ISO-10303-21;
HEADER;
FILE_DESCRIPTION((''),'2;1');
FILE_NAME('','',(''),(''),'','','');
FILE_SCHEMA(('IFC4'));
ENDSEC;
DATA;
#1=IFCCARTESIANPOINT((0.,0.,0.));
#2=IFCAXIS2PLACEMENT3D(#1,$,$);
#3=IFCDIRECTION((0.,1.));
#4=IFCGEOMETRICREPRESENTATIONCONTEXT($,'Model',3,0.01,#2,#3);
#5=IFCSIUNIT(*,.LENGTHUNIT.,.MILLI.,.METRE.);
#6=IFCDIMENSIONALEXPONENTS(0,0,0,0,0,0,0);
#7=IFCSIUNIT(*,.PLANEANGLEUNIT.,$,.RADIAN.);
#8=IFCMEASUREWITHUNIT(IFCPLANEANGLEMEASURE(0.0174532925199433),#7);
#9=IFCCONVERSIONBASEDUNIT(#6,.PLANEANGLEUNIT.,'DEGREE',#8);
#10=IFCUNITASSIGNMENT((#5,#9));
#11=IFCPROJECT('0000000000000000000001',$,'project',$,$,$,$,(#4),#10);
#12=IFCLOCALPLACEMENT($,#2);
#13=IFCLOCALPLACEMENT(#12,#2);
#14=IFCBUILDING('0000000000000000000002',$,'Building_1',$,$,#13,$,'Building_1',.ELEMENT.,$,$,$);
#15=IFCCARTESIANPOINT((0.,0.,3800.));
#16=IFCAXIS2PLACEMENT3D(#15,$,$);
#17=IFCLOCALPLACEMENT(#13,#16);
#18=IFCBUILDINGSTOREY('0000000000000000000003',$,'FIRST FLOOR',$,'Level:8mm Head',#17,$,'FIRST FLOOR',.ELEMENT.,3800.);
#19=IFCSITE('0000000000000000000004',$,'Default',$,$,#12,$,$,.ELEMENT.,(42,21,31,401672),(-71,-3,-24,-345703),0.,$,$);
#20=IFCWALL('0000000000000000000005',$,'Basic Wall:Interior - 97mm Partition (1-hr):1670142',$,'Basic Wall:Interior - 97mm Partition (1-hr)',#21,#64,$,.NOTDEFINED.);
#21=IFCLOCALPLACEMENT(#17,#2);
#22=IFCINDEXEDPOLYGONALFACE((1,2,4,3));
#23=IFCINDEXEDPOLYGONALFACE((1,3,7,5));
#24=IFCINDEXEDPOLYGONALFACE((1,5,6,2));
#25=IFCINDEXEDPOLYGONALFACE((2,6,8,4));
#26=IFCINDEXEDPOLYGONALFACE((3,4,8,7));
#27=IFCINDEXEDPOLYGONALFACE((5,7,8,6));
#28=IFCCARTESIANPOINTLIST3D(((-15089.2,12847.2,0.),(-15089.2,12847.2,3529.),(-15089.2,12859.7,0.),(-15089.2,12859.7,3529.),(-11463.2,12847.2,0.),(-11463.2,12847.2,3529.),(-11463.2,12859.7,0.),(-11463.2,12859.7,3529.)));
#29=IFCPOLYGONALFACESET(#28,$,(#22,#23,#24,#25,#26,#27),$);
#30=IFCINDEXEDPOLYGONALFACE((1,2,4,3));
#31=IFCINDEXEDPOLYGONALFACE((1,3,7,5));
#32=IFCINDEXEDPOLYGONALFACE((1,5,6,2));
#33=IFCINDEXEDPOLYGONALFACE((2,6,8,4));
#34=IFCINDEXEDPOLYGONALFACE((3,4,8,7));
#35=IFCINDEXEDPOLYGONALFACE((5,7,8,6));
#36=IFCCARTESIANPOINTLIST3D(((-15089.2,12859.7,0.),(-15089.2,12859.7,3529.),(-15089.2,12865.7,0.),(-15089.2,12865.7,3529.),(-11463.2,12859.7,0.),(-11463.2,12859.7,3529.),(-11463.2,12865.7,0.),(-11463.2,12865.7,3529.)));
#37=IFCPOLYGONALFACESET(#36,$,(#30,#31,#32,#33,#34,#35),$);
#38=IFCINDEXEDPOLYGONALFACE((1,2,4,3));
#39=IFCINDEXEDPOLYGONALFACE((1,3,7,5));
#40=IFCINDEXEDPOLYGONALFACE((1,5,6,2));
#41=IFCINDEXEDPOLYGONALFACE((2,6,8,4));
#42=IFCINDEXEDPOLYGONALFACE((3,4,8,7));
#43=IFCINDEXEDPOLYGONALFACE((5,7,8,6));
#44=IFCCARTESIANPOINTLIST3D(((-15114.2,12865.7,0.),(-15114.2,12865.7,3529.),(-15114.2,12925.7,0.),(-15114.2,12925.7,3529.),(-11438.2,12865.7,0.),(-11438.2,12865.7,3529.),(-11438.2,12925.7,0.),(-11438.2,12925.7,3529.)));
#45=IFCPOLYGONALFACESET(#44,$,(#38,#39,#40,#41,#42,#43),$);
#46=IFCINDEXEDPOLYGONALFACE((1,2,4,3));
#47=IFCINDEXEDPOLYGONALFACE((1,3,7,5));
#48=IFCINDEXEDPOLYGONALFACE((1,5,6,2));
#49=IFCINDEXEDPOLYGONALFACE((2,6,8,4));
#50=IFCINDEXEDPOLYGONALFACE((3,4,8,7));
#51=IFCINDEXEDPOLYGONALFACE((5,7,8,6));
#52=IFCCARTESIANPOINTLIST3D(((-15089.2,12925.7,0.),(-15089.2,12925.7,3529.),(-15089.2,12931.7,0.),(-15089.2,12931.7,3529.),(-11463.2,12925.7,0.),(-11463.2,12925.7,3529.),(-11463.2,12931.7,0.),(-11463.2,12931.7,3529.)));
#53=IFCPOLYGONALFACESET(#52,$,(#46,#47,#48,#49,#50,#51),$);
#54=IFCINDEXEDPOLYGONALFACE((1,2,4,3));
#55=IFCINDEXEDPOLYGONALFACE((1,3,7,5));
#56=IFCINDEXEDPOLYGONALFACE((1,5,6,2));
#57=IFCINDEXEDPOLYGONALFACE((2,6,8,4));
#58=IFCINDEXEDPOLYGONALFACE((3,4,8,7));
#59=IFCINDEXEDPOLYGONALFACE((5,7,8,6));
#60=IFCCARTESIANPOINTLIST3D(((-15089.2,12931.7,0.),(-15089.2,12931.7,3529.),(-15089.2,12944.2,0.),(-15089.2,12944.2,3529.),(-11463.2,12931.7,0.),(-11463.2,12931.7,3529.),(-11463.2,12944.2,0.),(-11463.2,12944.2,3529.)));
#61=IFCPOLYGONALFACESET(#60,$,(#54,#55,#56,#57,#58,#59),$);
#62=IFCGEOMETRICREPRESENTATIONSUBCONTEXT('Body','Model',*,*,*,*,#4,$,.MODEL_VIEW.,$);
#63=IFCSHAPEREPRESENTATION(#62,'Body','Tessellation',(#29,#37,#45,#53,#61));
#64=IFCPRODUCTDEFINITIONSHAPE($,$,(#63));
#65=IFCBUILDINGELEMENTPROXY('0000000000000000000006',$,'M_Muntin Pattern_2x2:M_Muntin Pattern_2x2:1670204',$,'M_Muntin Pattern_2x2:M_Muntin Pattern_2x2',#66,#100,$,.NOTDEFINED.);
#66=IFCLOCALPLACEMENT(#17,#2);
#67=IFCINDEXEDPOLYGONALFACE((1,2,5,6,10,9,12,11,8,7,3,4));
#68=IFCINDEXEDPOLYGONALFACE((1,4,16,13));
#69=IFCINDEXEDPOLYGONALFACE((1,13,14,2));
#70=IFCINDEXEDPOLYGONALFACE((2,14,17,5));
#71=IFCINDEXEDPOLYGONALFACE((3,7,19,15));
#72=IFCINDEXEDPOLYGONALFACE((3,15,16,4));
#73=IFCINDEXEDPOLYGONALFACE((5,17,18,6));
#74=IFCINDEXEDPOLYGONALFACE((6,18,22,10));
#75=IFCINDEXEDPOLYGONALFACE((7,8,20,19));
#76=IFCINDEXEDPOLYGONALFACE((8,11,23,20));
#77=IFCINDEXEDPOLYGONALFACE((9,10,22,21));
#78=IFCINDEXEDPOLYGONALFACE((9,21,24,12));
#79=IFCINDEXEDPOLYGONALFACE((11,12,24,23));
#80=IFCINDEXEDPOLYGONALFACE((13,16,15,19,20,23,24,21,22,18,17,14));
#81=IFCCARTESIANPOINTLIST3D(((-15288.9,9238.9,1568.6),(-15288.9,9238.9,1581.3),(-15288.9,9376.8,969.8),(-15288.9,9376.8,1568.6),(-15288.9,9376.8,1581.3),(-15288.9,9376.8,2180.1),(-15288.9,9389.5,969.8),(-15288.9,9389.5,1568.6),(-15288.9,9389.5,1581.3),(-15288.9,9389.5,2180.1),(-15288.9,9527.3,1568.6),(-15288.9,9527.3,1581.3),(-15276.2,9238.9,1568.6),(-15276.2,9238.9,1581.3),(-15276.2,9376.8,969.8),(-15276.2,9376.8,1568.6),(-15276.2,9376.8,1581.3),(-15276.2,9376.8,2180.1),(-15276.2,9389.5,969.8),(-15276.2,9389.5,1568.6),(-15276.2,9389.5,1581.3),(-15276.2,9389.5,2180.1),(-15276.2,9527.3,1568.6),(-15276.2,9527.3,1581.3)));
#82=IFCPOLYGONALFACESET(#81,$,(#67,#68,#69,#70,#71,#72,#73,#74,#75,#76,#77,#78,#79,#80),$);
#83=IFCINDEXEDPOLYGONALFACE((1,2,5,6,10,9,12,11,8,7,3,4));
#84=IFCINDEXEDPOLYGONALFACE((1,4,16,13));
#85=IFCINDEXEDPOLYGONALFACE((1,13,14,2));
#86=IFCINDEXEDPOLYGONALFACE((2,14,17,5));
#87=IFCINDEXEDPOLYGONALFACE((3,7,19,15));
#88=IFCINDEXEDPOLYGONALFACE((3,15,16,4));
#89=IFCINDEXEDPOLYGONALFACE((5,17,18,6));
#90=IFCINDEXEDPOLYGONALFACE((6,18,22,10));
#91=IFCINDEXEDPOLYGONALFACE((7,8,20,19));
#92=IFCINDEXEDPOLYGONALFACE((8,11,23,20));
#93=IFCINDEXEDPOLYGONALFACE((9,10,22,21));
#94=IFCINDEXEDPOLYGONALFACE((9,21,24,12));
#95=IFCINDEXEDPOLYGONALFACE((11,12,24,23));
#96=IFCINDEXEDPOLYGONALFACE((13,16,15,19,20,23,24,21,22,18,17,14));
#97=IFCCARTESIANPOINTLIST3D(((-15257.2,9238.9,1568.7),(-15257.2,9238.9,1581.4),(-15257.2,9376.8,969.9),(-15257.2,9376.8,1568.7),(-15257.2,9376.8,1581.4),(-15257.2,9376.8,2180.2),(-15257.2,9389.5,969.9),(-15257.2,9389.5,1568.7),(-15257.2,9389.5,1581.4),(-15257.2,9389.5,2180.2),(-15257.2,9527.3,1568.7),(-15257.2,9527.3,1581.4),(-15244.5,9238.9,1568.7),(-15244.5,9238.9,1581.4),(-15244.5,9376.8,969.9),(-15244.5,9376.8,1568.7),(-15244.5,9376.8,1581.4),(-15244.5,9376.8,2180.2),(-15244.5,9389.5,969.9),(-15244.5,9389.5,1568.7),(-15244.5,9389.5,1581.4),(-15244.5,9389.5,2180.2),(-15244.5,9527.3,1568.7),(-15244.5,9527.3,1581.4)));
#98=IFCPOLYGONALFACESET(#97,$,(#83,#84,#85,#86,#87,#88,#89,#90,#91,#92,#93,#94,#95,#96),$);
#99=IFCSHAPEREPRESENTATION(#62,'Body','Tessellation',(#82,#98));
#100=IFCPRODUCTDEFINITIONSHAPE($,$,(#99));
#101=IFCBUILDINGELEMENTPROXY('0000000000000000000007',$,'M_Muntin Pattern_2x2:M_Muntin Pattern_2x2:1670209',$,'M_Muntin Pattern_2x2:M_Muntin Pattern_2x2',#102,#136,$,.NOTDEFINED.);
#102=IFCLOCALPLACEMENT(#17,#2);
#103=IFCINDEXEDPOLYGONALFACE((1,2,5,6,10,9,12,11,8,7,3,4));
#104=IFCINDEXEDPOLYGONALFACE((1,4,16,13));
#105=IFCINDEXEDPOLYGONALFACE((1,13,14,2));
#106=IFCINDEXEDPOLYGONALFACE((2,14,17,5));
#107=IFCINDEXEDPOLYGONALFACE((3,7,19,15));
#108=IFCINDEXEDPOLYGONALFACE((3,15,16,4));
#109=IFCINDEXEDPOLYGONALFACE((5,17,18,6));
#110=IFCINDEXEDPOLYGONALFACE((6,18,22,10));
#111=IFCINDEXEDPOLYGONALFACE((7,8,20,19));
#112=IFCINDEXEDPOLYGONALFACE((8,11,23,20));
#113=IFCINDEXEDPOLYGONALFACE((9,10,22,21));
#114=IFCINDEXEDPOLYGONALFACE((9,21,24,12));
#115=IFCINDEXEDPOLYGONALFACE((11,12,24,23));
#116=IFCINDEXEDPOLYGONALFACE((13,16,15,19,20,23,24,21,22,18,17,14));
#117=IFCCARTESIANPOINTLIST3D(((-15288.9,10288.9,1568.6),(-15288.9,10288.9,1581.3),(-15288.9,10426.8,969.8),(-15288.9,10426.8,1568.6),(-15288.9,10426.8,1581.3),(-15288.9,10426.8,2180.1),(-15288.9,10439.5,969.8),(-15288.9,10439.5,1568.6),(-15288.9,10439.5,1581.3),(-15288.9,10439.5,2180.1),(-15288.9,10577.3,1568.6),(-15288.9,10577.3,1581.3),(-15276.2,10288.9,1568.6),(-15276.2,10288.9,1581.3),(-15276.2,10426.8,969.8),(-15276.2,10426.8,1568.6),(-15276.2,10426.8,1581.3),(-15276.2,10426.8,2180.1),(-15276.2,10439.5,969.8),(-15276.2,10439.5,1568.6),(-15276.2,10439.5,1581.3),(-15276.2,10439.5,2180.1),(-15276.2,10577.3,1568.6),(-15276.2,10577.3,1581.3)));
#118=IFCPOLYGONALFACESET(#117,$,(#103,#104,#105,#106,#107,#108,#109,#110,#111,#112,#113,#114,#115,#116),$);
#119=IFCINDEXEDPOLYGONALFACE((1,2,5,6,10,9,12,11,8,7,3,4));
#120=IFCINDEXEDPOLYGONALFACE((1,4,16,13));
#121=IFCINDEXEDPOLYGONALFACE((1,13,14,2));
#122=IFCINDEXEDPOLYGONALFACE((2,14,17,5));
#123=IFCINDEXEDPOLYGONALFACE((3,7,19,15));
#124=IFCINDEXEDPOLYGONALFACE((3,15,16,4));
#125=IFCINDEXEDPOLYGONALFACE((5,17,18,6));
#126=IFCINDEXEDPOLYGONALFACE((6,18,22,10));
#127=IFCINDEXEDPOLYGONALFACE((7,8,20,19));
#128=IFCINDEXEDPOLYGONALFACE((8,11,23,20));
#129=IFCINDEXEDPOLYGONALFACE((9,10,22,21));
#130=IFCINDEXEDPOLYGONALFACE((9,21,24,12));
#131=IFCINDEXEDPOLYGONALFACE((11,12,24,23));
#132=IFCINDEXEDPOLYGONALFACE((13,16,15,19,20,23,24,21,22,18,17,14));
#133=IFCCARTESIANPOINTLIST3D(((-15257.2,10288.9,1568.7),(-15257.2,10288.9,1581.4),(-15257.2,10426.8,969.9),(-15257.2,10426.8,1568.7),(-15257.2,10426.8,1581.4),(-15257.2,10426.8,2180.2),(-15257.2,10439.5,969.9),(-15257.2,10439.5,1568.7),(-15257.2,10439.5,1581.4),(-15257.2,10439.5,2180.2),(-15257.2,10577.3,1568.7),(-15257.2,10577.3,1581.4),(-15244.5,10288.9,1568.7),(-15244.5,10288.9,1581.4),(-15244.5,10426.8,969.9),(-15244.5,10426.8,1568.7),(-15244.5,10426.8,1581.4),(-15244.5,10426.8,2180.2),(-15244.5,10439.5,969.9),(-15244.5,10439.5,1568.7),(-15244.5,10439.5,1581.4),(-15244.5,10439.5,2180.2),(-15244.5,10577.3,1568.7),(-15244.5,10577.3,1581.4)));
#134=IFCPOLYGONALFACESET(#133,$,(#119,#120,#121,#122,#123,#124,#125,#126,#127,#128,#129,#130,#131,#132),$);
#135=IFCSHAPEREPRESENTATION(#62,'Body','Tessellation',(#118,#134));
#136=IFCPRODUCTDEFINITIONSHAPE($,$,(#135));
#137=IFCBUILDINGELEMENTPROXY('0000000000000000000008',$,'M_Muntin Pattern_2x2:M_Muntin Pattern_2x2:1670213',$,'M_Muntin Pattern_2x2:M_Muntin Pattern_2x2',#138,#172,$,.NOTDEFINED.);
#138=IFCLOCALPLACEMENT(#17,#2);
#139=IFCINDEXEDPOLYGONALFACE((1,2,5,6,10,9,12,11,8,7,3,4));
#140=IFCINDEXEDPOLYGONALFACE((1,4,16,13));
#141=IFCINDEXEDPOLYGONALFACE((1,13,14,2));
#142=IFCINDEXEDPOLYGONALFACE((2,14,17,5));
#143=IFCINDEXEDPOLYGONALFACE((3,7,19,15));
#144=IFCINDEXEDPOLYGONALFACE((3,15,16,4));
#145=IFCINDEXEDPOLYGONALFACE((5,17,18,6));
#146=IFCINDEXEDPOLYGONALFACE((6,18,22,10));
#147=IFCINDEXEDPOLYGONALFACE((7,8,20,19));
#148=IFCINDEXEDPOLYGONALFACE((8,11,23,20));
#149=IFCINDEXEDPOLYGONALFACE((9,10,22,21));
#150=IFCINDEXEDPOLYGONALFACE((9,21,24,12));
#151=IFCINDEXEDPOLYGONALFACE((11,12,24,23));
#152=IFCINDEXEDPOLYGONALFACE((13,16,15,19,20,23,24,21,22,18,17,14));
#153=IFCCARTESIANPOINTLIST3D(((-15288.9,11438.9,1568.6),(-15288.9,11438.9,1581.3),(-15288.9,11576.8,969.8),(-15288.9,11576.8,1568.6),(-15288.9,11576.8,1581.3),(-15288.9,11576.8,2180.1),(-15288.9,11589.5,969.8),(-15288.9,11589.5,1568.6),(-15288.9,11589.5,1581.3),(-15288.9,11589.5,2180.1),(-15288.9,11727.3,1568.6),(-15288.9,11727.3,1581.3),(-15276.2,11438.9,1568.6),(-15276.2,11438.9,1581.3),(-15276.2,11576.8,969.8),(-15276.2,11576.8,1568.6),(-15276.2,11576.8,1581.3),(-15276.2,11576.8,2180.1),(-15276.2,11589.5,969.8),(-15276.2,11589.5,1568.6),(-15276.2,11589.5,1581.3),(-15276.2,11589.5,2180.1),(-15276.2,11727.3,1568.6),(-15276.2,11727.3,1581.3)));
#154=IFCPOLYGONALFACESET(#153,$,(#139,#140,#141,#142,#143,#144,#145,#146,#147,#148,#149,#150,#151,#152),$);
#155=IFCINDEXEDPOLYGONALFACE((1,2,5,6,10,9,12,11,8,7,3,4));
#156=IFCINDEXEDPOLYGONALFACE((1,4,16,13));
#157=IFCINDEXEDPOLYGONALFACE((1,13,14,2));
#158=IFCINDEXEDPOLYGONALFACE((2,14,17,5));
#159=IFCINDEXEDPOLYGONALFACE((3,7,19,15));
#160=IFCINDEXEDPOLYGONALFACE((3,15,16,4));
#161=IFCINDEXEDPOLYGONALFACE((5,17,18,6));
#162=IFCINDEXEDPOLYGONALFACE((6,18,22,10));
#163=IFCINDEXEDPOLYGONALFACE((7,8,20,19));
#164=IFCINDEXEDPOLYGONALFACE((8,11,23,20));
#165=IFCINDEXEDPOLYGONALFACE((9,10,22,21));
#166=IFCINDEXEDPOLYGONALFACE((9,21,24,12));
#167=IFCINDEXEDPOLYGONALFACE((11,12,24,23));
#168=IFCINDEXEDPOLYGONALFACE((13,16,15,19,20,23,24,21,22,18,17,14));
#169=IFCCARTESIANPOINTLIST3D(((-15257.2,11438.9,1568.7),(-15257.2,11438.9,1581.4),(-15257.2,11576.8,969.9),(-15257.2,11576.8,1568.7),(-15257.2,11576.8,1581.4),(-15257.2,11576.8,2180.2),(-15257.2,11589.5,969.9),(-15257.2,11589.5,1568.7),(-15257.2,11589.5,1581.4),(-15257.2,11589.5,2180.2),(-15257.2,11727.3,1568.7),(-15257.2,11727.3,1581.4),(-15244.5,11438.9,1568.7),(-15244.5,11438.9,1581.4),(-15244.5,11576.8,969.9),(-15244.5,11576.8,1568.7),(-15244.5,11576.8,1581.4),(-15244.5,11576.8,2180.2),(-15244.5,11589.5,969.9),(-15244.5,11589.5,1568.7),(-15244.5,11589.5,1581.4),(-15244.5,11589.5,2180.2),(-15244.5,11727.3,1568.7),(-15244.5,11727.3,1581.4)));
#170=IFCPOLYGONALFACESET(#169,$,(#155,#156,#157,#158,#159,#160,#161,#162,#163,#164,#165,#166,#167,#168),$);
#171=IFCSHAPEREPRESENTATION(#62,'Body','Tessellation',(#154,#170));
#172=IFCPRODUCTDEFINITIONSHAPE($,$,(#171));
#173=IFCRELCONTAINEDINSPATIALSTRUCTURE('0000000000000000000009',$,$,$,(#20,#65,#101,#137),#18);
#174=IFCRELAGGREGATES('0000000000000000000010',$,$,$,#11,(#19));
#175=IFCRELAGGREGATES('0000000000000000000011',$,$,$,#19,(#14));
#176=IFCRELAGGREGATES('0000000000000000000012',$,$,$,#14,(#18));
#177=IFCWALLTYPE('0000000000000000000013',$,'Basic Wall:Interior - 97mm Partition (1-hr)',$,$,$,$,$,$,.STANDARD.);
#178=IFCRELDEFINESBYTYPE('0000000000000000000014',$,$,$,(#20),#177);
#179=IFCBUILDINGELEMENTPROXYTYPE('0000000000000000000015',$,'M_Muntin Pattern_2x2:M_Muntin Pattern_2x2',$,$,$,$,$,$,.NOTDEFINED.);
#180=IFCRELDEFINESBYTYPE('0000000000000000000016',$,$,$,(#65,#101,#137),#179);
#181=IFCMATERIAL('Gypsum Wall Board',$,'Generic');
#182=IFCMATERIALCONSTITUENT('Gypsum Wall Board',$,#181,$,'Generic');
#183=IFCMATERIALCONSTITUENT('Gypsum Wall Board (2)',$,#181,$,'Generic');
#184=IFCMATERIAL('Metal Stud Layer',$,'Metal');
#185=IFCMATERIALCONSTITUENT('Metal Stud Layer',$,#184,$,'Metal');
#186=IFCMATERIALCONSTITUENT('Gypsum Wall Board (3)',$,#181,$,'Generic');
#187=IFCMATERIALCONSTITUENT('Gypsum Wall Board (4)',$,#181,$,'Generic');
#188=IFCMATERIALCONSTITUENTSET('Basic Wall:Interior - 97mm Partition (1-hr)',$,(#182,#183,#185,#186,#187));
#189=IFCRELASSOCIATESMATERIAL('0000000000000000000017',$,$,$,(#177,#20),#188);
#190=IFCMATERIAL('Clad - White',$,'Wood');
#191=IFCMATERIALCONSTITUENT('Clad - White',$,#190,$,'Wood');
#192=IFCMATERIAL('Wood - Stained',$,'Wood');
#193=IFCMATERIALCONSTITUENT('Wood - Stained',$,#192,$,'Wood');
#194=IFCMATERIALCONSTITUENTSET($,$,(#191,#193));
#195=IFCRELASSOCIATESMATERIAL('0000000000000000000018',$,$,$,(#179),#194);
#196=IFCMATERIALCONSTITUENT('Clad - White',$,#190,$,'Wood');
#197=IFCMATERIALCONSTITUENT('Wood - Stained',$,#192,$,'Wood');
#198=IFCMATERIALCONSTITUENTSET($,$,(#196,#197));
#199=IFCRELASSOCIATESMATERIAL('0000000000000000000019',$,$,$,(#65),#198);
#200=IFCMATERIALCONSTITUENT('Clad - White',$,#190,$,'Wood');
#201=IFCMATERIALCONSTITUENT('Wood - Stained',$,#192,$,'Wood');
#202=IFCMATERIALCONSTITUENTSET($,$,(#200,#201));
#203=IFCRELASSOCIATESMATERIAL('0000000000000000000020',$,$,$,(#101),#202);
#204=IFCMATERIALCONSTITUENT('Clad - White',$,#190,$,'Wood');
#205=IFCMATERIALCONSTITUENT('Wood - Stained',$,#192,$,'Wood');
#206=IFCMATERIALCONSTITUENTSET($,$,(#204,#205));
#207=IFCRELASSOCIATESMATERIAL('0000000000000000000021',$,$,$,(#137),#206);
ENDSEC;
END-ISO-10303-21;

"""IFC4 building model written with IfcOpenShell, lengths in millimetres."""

from ifc_helpers import new_model, entity, si_unit, converted_unit, direction, frame, origin, place, context, subcontext, project, spatial, indexed_curve, outline, extrude, source, transform, mapped, material, constituent, constituent_set, type_object, type_shapes, element, save


model = new_model("IFC4")

# Units and contexts
model_context = context("Model", 3, precision=0.01, world=origin(), true_north=direction((0.0, 1.0)))
body_context = subcontext(model_context, "Body", "Model", "MODEL_VIEW")
ifc_project = project(units=[si_unit("LENGTHUNIT", "METRE", prefix="MILLI"), converted_unit("PLANEANGLEUNIT", "DEGREE", entity("IfcPlaneAngleMeasure", 0.0174532925199433), si_unit("PLANEANGLEUNIT", "RADIAN"), dimensions=[0, 0, 0, 0, 0, 0, 0])], contexts=[model_context])

# Site, building, storey
site_placement = place(None, origin())
site = spatial("IfcSite", under=ifc_project, at=site_placement, Name="Default", CompositionType="ELEMENT", RefLatitude=(42, 21, 31, 401672), RefLongitude=(-71, -3, -24, -345703), RefElevation=0.0)
building_placement = place(site_placement, origin())
building = spatial("IfcBuilding", under=site, at=building_placement, Name="Building_1", LongName="Building_1", CompositionType="ELEMENT")
storey_placement = place(building_placement, frame((0.0, 0.0, 3800.0)))
storey = spatial("IfcBuildingStorey", under=building, at=storey_placement, Name="FIRST FLOOR", ObjectType="Level:8mm Head", LongName="FIRST FLOOR", CompositionType="ELEMENT", Elevation=3800.0)

# Shared definitions
ifc_material_1 = material(Name="Wood - Stained", Category="Wood")

# Wall
ifc_material_2 = material(Name="Gypsum Wall Board", Category="Generic")
ifc_constituent_1 = constituent(ifc_material_2, Name="Gypsum Wall Board", Category="Generic")
ifc_constituent_2 = constituent(ifc_material_2, Name="Gypsum Wall Board (2)", Category="Generic")
ifc_material_3 = material(Name="Metal Stud Layer", Category="Metal")
ifc_constituent_3 = constituent(ifc_material_3, Name="Metal Stud Layer", Category="Metal")
ifc_constituent_4 = constituent(ifc_material_2, Name="Gypsum Wall Board (3)", Category="Generic")
ifc_constituent_5 = constituent(ifc_material_2, Name="Gypsum Wall Board (4)", Category="Generic")
ifc_constituent_set_1 = constituent_set(constituents=[ifc_constituent_1, ifc_constituent_2, ifc_constituent_3, ifc_constituent_4, ifc_constituent_5], Name="Basic Wall:Interior - 97mm Partition (1-hr)")
wall_type_1 = type_object("IfcWallType", Name="Basic Wall:Interior - 97mm Partition (1-hr)", PredefinedType="STANDARD", material=ifc_constituent_set_1)
wall_1_placement = place(storey_placement, frame((-15089.2, 12895.7, 0.0)))
element("IfcWall", 1, at=wall_1_placement, inside=storey, type_object=wall_type_1, material=ifc_constituent_set_1, Name="Basic Wall:Interior - 97mm Partition (1-hr):1670142", ObjectType="Basic Wall:Interior - 97mm Partition (1-hr)", PredefinedType="NOTDEFINED", context=body_context, shape_type="SweptSolid", body=[
    extrude(outline(indexed_curve([(-6.3, -1813.0), (6.2, -1813.0), (6.3, 1813.0), (-6.2, 1813.0), (-6.3, -1813.0)], self_intersect=False)), frame((1813.0, -42.2, 0.0), z_axis=(0.0, 0.0, 1.0), x_axis=(0.0, 1.0, 0.0)), (0.0, 0.0, 1.0), 3529.0),
    extrude(outline(indexed_curve([(-1813.0, -3.0), (1813.0, -3.0), (1813.0, 3.0), (-1813.0, 3.0), (-1813.0, -3.0)], self_intersect=False)), frame((1813.0, -33.0, 0.0)), (0.0, 0.0, 1.0), 3529.0),
    extrude(outline(indexed_curve([(-1838.0, -30.0), (1838.0, -30.0), (1838.0, 30.0), (-1838.0, 30.0), (-1838.0, -30.0)], self_intersect=False)), frame((1813.0, 0.0, 0.0)), (0.0, 0.0, 1.0), 3529.0),
    extrude(outline(indexed_curve([(-1813.0, -3.0), (1813.0, -3.0), (1813.0, 3.0), (-1813.0, 3.0), (-1813.0, -3.0)], self_intersect=False)), frame((1813.0, 33.0, 0.0)), (0.0, 0.0, 1.0), 3529.0),
    extrude(outline(indexed_curve([(-6.3, -1813.0), (6.2, -1813.0), (6.3, 1813.0), (-6.2, 1813.0), (-6.3, -1813.0)], self_intersect=False)), frame((1813.0, 42.2, 0.0), z_axis=(0.0, 0.0, 1.0), x_axis=(0.0, -1.0, 0.0)), (0.0, 0.0, 1.0), 3529.0),
])

# Building element proxies
ifc_material_4 = material(Name="Clad - White", Category="Wood")
ifc_constituent_6 = constituent(ifc_material_4, Name="Clad - White", Category="Wood")
ifc_constituent_7 = constituent(ifc_material_1, Name="Wood - Stained", Category="Wood")
ifc_constituent_set_2 = constituent_set(constituents=[ifc_constituent_6, ifc_constituent_7])
ifc_constituent_8 = constituent(ifc_material_4, Name="Clad - White", Category="Wood")
ifc_constituent_9 = constituent(ifc_material_1, Name="Wood - Stained", Category="Wood")
ifc_constituent_set_3 = constituent_set(constituents=[ifc_constituent_8, ifc_constituent_9])
building_element_proxy_type_1 = type_object("IfcBuildingElementProxyType", Name="M_Muntin Pattern_2x2:M_Muntin Pattern_2x2", PredefinedType="NOTDEFINED", material=ifc_constituent_set_3)
shared_shape_1 = source(origin(), body_context, "Body", "SweptSolid", [
    extrude(outline(indexed_curve([(6.4, -6.4), (605.1, -6.4), (605.1, 6.3), (6.4, 6.3), (6.4, 144.2), (-6.3, 144.2), (-6.3, 6.3), (-605.2, 6.3), (-605.2, -6.4), (-6.3, -6.4), (-6.3, -144.2), (6.4, -144.2), (6.4, -6.4)], self_intersect=False)), frame((0.0, -22.2, 605.1), z_axis=(0.0, 1.0, 0.0), x_axis=(0.0, 0.0, 1.0)), (0.0, 0.0, 1.0), 12.7),
    extrude(outline(indexed_curve([(6.4, -6.4), (605.2, -6.4), (605.2, 6.3), (6.4, 6.3), (6.4, 144.2), (-6.3, 144.2), (-6.3, 6.3), (-605.2, 6.3), (-605.2, -6.4), (-6.3, -6.4), (-6.3, -144.2), (6.4, -144.2), (6.4, -6.4)], self_intersect=False)), frame((0.0, 9.5, 605.2), z_axis=(0.0, 1.0, 0.0), x_axis=(0.0, 0.0, 1.0)), (0.0, 0.0, 1.0), 12.7),
])
type_shapes(building_element_proxy_type_1, [shared_shape_1])
proxy_1_placement = place(storey_placement, frame((-15266.7, 9383.1, 969.9), z_axis=(0.0, 0.0, 1.0), x_axis=(0.0, -1.0, 0.0)))
element("IfcBuildingElementProxy", 2, at=proxy_1_placement, inside=storey, type_object=building_element_proxy_type_1, material=ifc_constituent_set_2, Name="M_Muntin Pattern_2x2:M_Muntin Pattern_2x2:1670204", ObjectType="M_Muntin Pattern_2x2:M_Muntin Pattern_2x2", PredefinedType="NOTDEFINED", context=body_context, shape_type="MappedRepresentation", body=[
    mapped(shared_shape_1, transform((0.0, 0.0, 0.0), scale=1.0)),
])
ifc_constituent_10 = constituent(ifc_material_4, Name="Clad - White", Category="Wood")
ifc_constituent_11 = constituent(ifc_material_1, Name="Wood - Stained", Category="Wood")
ifc_constituent_set_4 = constituent_set(constituents=[ifc_constituent_10, ifc_constituent_11])
proxy_2_placement = place(storey_placement, frame((-15266.7, 10433.1, 969.9), z_axis=(0.0, 0.0, 1.0), x_axis=(0.0, -1.0, 0.0)))
element("IfcBuildingElementProxy", 3, at=proxy_2_placement, inside=storey, type_object=building_element_proxy_type_1, material=ifc_constituent_set_4, Name="M_Muntin Pattern_2x2:M_Muntin Pattern_2x2:1670209", ObjectType="M_Muntin Pattern_2x2:M_Muntin Pattern_2x2", PredefinedType="NOTDEFINED", context=body_context, shape_type="MappedRepresentation", body=[
    mapped(shared_shape_1, transform((0.0, 0.0, 0.0), scale=1.0)),
])
ifc_constituent_12 = constituent(ifc_material_4, Name="Clad - White", Category="Wood")
ifc_constituent_13 = constituent(ifc_material_1, Name="Wood - Stained", Category="Wood")
ifc_constituent_set_5 = constituent_set(constituents=[ifc_constituent_12, ifc_constituent_13])
proxy_3_placement = place(storey_placement, frame((-15266.7, 11583.1, 969.9), z_axis=(0.0, 0.0, 1.0), x_axis=(0.0, -1.0, 0.0)))
element("IfcBuildingElementProxy", 4, at=proxy_3_placement, inside=storey, type_object=building_element_proxy_type_1, material=ifc_constituent_set_5, Name="M_Muntin Pattern_2x2:M_Muntin Pattern_2x2:1670213", ObjectType="M_Muntin Pattern_2x2:M_Muntin Pattern_2x2", PredefinedType="NOTDEFINED", context=body_context, shape_type="MappedRepresentation", body=[
    mapped(shared_shape_1, transform((0.0, 0.0, 0.0), scale=1.0)),
])

save(model, "model.ifc")
